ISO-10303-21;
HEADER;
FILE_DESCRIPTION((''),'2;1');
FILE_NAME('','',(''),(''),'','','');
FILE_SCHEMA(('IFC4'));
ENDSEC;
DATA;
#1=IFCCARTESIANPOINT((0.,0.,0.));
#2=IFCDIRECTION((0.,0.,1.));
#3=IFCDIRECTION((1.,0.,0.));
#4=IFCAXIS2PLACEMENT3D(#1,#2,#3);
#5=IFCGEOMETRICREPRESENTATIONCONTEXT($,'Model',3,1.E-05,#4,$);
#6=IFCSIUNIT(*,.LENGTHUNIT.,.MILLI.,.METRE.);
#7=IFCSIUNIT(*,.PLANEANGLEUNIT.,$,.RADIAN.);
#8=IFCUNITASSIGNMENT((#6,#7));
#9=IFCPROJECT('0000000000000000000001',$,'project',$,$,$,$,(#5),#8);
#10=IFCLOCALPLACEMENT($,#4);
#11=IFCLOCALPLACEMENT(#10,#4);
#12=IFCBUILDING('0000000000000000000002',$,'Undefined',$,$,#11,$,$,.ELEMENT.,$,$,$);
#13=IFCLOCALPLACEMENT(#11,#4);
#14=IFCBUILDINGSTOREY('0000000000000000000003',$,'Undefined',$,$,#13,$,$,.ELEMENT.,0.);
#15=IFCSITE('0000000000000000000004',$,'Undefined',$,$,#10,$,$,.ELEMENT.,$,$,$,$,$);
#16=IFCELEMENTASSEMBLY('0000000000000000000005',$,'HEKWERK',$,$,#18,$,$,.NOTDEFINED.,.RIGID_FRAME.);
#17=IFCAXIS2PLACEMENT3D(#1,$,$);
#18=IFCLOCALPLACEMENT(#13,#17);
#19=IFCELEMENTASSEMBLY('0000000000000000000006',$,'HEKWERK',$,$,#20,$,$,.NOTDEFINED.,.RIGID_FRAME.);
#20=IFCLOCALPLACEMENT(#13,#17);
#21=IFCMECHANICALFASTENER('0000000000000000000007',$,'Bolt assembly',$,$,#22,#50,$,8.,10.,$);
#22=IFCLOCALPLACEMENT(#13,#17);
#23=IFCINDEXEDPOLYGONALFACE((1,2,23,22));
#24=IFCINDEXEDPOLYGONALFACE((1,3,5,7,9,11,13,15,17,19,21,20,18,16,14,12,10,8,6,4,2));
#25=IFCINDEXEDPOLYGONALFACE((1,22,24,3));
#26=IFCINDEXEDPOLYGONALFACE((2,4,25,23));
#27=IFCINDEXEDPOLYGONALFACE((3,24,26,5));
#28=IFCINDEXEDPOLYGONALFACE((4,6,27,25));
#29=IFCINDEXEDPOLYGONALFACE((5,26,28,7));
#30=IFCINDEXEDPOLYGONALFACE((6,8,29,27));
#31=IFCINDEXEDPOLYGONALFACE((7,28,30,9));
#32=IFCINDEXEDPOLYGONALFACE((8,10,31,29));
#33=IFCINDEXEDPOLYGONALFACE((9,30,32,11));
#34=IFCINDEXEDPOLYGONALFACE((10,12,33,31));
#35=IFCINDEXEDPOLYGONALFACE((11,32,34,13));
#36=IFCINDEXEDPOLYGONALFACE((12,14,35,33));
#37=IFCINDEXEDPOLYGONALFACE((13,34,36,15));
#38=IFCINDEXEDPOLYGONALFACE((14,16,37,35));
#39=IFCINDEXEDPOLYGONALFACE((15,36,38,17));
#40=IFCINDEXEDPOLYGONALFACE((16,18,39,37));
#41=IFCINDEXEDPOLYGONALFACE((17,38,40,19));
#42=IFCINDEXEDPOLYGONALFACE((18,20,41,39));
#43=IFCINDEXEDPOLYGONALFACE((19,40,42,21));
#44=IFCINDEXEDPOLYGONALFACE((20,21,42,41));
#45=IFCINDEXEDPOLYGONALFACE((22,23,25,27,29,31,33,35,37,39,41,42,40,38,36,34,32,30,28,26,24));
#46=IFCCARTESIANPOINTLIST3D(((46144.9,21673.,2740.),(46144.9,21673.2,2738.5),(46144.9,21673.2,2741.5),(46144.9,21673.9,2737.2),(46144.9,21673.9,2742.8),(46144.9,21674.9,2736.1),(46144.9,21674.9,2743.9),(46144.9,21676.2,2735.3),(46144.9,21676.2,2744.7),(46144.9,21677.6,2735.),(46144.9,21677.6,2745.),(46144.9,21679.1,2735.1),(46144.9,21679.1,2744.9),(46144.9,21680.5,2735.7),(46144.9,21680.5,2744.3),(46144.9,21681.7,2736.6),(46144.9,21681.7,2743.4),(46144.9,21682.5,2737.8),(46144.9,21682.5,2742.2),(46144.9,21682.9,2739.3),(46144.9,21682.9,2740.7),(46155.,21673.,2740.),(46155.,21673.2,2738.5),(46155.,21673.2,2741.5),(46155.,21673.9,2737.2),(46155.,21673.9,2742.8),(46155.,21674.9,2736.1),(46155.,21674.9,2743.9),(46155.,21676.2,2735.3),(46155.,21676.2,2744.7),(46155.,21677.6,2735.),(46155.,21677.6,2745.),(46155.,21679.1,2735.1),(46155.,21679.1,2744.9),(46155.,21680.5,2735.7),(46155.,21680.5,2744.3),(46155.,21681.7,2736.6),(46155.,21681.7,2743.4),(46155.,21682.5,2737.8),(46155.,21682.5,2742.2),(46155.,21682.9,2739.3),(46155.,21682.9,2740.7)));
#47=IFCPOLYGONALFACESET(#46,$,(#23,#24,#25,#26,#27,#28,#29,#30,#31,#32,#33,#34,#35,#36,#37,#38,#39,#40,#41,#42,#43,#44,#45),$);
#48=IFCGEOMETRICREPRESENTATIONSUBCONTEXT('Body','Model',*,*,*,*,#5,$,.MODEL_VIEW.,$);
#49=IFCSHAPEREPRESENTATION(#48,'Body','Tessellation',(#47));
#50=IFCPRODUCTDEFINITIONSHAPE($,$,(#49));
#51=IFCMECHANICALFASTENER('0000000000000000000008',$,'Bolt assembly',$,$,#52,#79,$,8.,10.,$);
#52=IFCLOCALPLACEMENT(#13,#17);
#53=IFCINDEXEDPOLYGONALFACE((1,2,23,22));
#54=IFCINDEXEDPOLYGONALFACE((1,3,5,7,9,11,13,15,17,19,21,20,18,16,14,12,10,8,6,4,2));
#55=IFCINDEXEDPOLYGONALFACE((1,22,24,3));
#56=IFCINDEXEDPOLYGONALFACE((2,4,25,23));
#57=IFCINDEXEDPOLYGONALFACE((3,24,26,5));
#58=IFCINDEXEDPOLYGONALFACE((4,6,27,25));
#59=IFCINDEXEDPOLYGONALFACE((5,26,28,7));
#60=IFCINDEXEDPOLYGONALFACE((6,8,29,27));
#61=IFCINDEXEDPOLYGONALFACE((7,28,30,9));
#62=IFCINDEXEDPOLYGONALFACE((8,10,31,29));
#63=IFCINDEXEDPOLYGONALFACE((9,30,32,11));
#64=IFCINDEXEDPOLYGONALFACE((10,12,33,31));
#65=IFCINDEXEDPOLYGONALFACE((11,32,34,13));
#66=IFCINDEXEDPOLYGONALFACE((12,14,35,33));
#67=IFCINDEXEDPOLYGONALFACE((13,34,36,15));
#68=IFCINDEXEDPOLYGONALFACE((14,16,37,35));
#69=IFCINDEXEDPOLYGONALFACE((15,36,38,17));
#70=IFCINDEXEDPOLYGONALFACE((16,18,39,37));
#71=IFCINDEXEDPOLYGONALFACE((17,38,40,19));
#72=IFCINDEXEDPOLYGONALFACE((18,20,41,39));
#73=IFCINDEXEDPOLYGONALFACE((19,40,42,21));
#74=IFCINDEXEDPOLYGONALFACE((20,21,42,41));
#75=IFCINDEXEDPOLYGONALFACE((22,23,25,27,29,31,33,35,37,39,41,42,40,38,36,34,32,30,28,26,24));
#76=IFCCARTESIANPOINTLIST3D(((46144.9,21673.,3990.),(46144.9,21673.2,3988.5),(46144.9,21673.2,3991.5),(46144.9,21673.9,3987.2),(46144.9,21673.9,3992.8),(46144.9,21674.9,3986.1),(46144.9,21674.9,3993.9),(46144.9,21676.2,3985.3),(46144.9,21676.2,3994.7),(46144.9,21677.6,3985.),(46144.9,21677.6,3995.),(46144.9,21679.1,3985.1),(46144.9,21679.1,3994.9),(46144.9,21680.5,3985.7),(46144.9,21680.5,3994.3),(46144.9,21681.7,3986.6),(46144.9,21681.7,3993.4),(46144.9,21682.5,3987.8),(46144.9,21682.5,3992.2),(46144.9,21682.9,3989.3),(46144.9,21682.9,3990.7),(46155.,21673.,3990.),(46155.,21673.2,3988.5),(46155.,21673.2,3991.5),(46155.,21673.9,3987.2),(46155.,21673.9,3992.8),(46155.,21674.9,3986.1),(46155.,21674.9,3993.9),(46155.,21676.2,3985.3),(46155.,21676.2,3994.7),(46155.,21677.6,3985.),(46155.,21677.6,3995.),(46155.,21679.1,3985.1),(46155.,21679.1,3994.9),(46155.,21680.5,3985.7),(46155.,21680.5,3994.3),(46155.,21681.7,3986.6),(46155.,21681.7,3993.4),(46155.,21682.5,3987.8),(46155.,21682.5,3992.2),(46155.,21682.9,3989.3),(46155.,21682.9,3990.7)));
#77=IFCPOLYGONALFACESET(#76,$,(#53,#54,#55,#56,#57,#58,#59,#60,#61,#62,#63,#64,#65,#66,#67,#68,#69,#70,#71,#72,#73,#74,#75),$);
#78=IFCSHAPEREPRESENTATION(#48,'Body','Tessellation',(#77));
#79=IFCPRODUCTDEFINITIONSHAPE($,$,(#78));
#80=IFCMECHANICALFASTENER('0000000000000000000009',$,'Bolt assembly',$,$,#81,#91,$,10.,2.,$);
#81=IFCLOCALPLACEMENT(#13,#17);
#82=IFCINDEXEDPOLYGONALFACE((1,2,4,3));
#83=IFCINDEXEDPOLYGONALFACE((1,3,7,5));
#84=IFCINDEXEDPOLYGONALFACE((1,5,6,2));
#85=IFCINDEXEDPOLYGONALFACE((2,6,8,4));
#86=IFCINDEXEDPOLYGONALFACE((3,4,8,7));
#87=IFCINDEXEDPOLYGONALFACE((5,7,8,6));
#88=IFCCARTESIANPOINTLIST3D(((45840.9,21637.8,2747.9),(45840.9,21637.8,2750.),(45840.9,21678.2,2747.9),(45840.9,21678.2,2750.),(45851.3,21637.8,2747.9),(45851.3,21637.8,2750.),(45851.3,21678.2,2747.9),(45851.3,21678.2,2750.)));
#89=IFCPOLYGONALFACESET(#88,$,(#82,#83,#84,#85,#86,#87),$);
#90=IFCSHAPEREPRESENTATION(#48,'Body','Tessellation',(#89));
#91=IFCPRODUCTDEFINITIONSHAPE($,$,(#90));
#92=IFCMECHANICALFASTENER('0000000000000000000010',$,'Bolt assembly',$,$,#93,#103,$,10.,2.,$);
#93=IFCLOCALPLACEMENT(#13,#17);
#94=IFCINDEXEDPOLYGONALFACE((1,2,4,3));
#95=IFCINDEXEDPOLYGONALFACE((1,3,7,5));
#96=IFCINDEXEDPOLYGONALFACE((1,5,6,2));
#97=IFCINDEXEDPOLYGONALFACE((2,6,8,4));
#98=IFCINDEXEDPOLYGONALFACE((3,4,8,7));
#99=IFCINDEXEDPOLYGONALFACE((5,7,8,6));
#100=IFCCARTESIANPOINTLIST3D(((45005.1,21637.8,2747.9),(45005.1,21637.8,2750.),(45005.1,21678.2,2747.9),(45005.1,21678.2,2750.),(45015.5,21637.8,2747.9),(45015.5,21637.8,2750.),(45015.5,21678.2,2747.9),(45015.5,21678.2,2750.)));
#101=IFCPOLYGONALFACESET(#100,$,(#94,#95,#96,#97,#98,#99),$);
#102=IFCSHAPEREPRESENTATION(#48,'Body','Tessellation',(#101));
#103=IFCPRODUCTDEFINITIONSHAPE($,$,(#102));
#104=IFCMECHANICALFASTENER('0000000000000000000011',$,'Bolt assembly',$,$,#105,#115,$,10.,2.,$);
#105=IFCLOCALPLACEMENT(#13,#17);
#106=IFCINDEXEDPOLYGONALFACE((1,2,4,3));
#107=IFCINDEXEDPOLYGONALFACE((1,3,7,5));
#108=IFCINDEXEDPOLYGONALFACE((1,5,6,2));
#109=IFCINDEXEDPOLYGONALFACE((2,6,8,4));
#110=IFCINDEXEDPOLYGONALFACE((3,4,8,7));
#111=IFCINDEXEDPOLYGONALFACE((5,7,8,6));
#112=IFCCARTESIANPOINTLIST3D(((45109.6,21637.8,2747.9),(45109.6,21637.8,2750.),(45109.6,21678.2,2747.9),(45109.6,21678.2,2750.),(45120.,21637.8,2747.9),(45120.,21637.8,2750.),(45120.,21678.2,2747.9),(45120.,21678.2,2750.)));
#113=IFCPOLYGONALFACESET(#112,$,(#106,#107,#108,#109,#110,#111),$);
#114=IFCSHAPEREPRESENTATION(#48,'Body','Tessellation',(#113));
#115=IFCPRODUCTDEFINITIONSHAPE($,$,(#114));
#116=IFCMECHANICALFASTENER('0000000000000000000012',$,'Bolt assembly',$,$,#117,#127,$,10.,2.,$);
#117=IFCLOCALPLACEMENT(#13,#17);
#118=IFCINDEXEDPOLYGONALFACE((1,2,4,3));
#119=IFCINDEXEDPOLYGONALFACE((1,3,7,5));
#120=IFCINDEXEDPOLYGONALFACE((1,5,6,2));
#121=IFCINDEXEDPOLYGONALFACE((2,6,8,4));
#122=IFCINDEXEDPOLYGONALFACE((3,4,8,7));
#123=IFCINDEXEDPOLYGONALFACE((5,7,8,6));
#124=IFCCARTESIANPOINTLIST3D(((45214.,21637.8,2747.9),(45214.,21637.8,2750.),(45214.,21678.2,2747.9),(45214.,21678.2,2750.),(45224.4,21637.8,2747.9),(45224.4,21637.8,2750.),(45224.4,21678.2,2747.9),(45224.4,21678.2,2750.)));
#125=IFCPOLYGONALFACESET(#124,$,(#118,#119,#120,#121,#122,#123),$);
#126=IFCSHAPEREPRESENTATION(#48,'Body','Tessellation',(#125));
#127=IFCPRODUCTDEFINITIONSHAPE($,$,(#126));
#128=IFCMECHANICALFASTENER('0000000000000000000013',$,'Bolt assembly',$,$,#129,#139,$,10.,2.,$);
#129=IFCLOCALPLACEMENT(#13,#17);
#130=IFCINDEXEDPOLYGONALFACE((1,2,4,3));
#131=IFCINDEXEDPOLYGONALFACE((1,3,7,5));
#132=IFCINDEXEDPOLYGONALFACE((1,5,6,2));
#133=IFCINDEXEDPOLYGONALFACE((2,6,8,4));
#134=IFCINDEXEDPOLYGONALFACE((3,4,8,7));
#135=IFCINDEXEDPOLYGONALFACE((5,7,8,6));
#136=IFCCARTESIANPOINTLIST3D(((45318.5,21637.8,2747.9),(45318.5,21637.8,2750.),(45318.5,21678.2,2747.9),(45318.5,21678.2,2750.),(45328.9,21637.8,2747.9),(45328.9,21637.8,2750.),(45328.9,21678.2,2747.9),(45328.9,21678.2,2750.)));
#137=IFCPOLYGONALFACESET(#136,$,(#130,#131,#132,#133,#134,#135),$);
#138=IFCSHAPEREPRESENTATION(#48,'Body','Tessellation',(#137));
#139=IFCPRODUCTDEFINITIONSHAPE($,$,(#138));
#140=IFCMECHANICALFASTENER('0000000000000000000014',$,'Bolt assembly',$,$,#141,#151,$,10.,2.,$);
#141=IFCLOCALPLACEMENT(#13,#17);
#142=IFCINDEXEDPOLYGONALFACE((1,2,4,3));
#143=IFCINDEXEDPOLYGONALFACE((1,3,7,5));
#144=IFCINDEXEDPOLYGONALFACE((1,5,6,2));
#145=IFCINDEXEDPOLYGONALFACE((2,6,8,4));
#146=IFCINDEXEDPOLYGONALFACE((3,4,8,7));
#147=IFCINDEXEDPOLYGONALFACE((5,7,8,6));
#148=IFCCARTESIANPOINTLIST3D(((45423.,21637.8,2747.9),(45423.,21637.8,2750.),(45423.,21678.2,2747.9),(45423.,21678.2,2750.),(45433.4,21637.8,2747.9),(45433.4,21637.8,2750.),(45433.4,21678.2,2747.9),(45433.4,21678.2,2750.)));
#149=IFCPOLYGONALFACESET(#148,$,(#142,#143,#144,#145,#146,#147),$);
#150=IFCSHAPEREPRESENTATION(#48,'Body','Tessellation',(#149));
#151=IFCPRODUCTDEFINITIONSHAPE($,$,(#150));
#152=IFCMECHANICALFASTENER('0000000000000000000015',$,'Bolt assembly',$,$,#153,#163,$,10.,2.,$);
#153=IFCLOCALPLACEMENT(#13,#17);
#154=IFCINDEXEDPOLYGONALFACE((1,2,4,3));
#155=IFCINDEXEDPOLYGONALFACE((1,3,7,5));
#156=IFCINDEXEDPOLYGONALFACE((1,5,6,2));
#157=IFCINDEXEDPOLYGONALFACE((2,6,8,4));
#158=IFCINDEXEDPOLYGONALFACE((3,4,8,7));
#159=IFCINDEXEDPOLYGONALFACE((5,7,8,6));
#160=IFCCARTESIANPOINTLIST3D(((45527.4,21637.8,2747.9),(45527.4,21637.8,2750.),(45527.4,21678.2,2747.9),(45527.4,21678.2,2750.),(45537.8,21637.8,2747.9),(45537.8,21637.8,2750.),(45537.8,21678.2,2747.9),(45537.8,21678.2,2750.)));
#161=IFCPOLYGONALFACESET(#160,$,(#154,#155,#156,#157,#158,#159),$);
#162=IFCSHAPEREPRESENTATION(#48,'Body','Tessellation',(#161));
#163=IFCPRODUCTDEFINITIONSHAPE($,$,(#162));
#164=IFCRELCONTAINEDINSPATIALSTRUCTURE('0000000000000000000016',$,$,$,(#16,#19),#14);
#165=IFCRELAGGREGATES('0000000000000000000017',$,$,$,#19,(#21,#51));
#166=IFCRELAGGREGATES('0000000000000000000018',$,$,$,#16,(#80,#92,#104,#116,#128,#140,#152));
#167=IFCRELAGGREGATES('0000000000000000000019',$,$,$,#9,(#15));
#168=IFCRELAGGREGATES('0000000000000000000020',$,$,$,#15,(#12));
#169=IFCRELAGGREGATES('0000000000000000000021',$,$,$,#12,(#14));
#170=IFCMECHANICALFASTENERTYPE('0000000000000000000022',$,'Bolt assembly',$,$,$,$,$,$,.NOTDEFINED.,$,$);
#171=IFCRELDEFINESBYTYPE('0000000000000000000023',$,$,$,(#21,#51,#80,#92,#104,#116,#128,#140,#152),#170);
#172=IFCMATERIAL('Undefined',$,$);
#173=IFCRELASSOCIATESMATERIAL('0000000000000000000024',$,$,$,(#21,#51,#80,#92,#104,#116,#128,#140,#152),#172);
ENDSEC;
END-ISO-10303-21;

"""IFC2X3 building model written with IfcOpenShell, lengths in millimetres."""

from ifc_helpers import new_model, si_unit, frame, origin_with_axes, origin_2d_with_axis, place, context, subcontext, project, spatial, polyline, segment, composite_curve, circle, outline, extrude, source, transform, mapped, material, type_object, element, aggregate, save


model = new_model("IFC2X3")

# Units and contexts
model_context = context("Model", 3, precision=1e-05, world=origin_with_axes())
body_context = subcontext(model_context, "Body", "Model", "MODEL_VIEW")
ifc_project = project(units=[si_unit("LENGTHUNIT", "METRE", prefix="MILLI"), si_unit("PLANEANGLEUNIT", "RADIAN")], contexts=[model_context])

# Site, building, storey
site_placement = place(None, origin_with_axes())
site = spatial("IfcSite", under=ifc_project, at=site_placement, Name="Undefined", CompositionType="ELEMENT")
building_placement = place(site_placement, origin_with_axes())
building = spatial("IfcBuilding", under=site, at=building_placement, Name="Undefined", CompositionType="ELEMENT")
storey_placement = place(building_placement, origin_with_axes())
storey = spatial("IfcBuildingStorey", under=building, at=storey_placement, Name="Undefined", CompositionType="ELEMENT", Elevation=0.0)

# Element assembly
assembly_1_placement = place(storey_placement, origin_with_axes())
assembly_1 = element("IfcElementAssembly", 1, at=assembly_1_placement, inside=storey, Name="HEKWERK", AssemblyPlace="NOTDEFINED", PredefinedType="RIGID_FRAME")

# Element assembly
assembly_2_placement = place(storey_placement, origin_with_axes())
assembly_2 = element("IfcElementAssembly", 2, at=assembly_2_placement, inside=storey, Name="HEKWERK", AssemblyPlace="NOTDEFINED", PredefinedType="RIGID_FRAME")

# Mechanical fasteners
ifc_material_1 = material(Name="Undefined")
mechanical_fastener_type = type_object("IfcMechanicalFastenerType", Name="Bolt assembly")
shared_shape_1 = source(origin_with_axes(), body_context, "Body", "SweptSolid", [
    extrude(circle(Radius=5.0, at=origin_2d_with_axis()), frame((0.0, 0.0, 0.0), z_axis=(0.0, 1.0, 0.0), x_axis=(1.0, 0.0, 0.0)), (0.0, 0.0, 1.0), 10.1),
])
mechanical_fastener_1_placement = place(assembly_2_placement, frame((46155.0, 21678.0, 2740.0), z_axis=(0.0, 0.0, -1.0), x_axis=(0.0, -1.0, 0.0)))
mechanical_fastener_1 = element("IfcMechanicalFastener", 3, at=mechanical_fastener_1_placement, type_object=mechanical_fastener_type, material=ifc_material_1, Name="Bolt assembly", NominalDiameter=8.0, NominalLength=10.0, context=body_context, shape_type="MappedRepresentation", body=[
    mapped(shared_shape_1, transform((0.0, 0.0, 0.0))),
])
mechanical_fastener_2_placement = place(assembly_2_placement, frame((46155.0, 21678.0, 3990.0), z_axis=(0.0, 0.0, -1.0), x_axis=(0.0, -1.0, 0.0)))
mechanical_fastener_2 = element("IfcMechanicalFastener", 4, at=mechanical_fastener_2_placement, type_object=mechanical_fastener_type, material=ifc_material_1, Name="Bolt assembly", NominalDiameter=8.0, NominalLength=10.0, context=body_context, shape_type="MappedRepresentation", body=[
    mapped(shared_shape_1, transform((0.0, 0.0, 0.0))),
])
shared_shape_2 = source(origin_with_axes(), body_context, "Body", "SweptSolid", [
    extrude(outline(composite_curve([segment(polyline([(-20.2, 5.2), (20.2, 5.2)]), True, "CONTINUOUS"), segment(polyline([(20.2, 5.2), (20.2, -5.2)]), True, "CONTINUOUS"), segment(polyline([(20.2, -5.2), (-20.2, -5.2)]), True, "CONTINUOUS"), segment(polyline([(-20.2, -5.2), (-20.2, 5.2)]), True, "CONTINUOUS")], self_intersect=False)), frame((0.0, -1.0, 0.0), z_axis=(0.0, 1.0, 0.0), x_axis=(1.0, 0.0, 0.0)), (0.0, 0.0, 1.0), 2.1),
])
mechanical_fastener_3_placement = place(assembly_1_placement, frame((45846.1, 21658.0, 2749.0), z_axis=(-1.0, 0.0, 0.0), x_axis=(0.0, 1.0, 0.0)))
mechanical_fastener_3 = element("IfcMechanicalFastener", 5, at=mechanical_fastener_3_placement, type_object=mechanical_fastener_type, material=ifc_material_1, Name="Bolt assembly", NominalDiameter=10.0, NominalLength=2.0, context=body_context, shape_type="MappedRepresentation", body=[
    mapped(shared_shape_2, transform((0.0, 0.0, 0.0))),
])
shared_shape_3 = source(origin_with_axes(), body_context, "Body", "SweptSolid", [
    extrude(outline(composite_curve([segment(polyline([(-20.2, 5.2), (20.2, 5.2)]), True, "CONTINUOUS"), segment(polyline([(20.2, 5.2), (20.2, -5.2)]), True, "CONTINUOUS"), segment(polyline([(20.2, -5.2), (-20.2, -5.2)]), True, "CONTINUOUS"), segment(polyline([(-20.2, -5.2), (-20.2, 5.2)]), True, "CONTINUOUS")], self_intersect=False)), frame((0.0, -1.0, 0.0), z_axis=(0.0, 1.0, 0.0), x_axis=(1.0, 0.0, 0.0)), (0.0, 0.0, 1.0), 2.1),
])
mechanical_fastener_4_placement = place(assembly_1_placement, frame((45010.3, 21658.0, 2749.0), z_axis=(-1.0, 0.0, 0.0), x_axis=(0.0, 1.0, 0.0)))
mechanical_fastener_4 = element("IfcMechanicalFastener", 6, at=mechanical_fastener_4_placement, type_object=mechanical_fastener_type, material=ifc_material_1, Name="Bolt assembly", NominalDiameter=10.0, NominalLength=2.0, context=body_context, shape_type="MappedRepresentation", body=[
    mapped(shared_shape_3, transform((0.0, 0.0, 0.0))),
])
shared_shape_4 = source(origin_with_axes(), body_context, "Body", "SweptSolid", [
    extrude(outline(composite_curve([segment(polyline([(-20.2, 5.2), (20.2, 5.2)]), True, "CONTINUOUS"), segment(polyline([(20.2, 5.2), (20.2, -5.2)]), True, "CONTINUOUS"), segment(polyline([(20.2, -5.2), (-20.2, -5.2)]), True, "CONTINUOUS"), segment(polyline([(-20.2, -5.2), (-20.2, 5.2)]), True, "CONTINUOUS")], self_intersect=False)), frame((0.0, -1.0, 0.0), z_axis=(0.0, 1.0, 0.0), x_axis=(1.0, 0.0, 0.0)), (0.0, 0.0, 1.0), 2.1),
])
mechanical_fastener_5_placement = place(assembly_1_placement, frame((45114.8, 21658.0, 2749.0), z_axis=(-1.0, 0.0, 0.0), x_axis=(0.0, 1.0, 0.0)))
mechanical_fastener_5 = element("IfcMechanicalFastener", 7, at=mechanical_fastener_5_placement, type_object=mechanical_fastener_type, material=ifc_material_1, Name="Bolt assembly", NominalDiameter=10.0, NominalLength=2.0, context=body_context, shape_type="MappedRepresentation", body=[
    mapped(shared_shape_4, transform((0.0, 0.0, 0.0))),
])
shared_shape_5 = source(origin_with_axes(), body_context, "Body", "SweptSolid", [
    extrude(outline(composite_curve([segment(polyline([(-20.2, 5.2), (20.2, 5.2)]), True, "CONTINUOUS"), segment(polyline([(20.2, 5.2), (20.2, -5.2)]), True, "CONTINUOUS"), segment(polyline([(20.2, -5.2), (-20.2, -5.2)]), True, "CONTINUOUS"), segment(polyline([(-20.2, -5.2), (-20.2, 5.2)]), True, "CONTINUOUS")], self_intersect=False)), frame((0.0, -1.0, 0.0), z_axis=(0.0, 1.0, 0.0), x_axis=(1.0, 0.0, 0.0)), (0.0, 0.0, 1.0), 2.1),
])
mechanical_fastener_6_placement = place(assembly_1_placement, frame((45219.2, 21658.0, 2749.0), z_axis=(-1.0, 0.0, 0.0), x_axis=(0.0, 1.0, 0.0)))
mechanical_fastener_6 = element("IfcMechanicalFastener", 8, at=mechanical_fastener_6_placement, type_object=mechanical_fastener_type, material=ifc_material_1, Name="Bolt assembly", NominalDiameter=10.0, NominalLength=2.0, context=body_context, shape_type="MappedRepresentation", body=[
    mapped(shared_shape_5, transform((0.0, 0.0, 0.0))),
])
shared_shape_6 = source(origin_with_axes(), body_context, "Body", "SweptSolid", [
    extrude(outline(composite_curve([segment(polyline([(-20.2, 5.2), (20.2, 5.2)]), True, "CONTINUOUS"), segment(polyline([(20.2, 5.2), (20.2, -5.2)]), True, "CONTINUOUS"), segment(polyline([(20.2, -5.2), (-20.2, -5.2)]), True, "CONTINUOUS"), segment(polyline([(-20.2, -5.2), (-20.2, 5.2)]), True, "CONTINUOUS")], self_intersect=False)), frame((0.0, -1.0, 0.0), z_axis=(0.0, 1.0, 0.0), x_axis=(1.0, 0.0, 0.0)), (0.0, 0.0, 1.0), 2.1),
])
mechanical_fastener_7_placement = place(assembly_1_placement, frame((45323.7, 21658.0, 2749.0), z_axis=(-1.0, 0.0, 0.0), x_axis=(0.0, 1.0, 0.0)))
mechanical_fastener_7 = element("IfcMechanicalFastener", 9, at=mechanical_fastener_7_placement, type_object=mechanical_fastener_type, material=ifc_material_1, Name="Bolt assembly", NominalDiameter=10.0, NominalLength=2.0, context=body_context, shape_type="MappedRepresentation", body=[
    mapped(shared_shape_6, transform((0.0, 0.0, 0.0))),
])
shared_shape_7 = source(origin_with_axes(), body_context, "Body", "SweptSolid", [
    extrude(outline(composite_curve([segment(polyline([(-20.2, 5.2), (20.2, 5.2)]), True, "CONTINUOUS"), segment(polyline([(20.2, 5.2), (20.2, -5.2)]), True, "CONTINUOUS"), segment(polyline([(20.2, -5.2), (-20.2, -5.2)]), True, "CONTINUOUS"), segment(polyline([(-20.2, -5.2), (-20.2, 5.2)]), True, "CONTINUOUS")], self_intersect=False)), frame((0.0, -1.0, 0.0), z_axis=(0.0, 1.0, 0.0), x_axis=(1.0, 0.0, 0.0)), (0.0, 0.0, 1.0), 2.1),
])
mechanical_fastener_8_placement = place(assembly_1_placement, frame((45428.2, 21658.0, 2749.0), z_axis=(-1.0, 0.0, 0.0), x_axis=(0.0, 1.0, 0.0)))
mechanical_fastener_8 = element("IfcMechanicalFastener", 10, at=mechanical_fastener_8_placement, type_object=mechanical_fastener_type, material=ifc_material_1, Name="Bolt assembly", NominalDiameter=10.0, NominalLength=2.0, context=body_context, shape_type="MappedRepresentation", body=[
    mapped(shared_shape_7, transform((0.0, 0.0, 0.0))),
])
shared_shape_8 = source(origin_with_axes(), body_context, "Body", "SweptSolid", [
    extrude(outline(composite_curve([segment(polyline([(-20.2, 5.2), (20.2, 5.2)]), True, "CONTINUOUS"), segment(polyline([(20.2, 5.2), (20.2, -5.2)]), True, "CONTINUOUS"), segment(polyline([(20.2, -5.2), (-20.2, -5.2)]), True, "CONTINUOUS"), segment(polyline([(-20.2, -5.2), (-20.2, 5.2)]), True, "CONTINUOUS")], self_intersect=False)), frame((0.0, -1.0, 0.0), z_axis=(0.0, 1.0, 0.0), x_axis=(1.0, 0.0, 0.0)), (0.0, 0.0, 1.0), 2.1),
])
mechanical_fastener_9_placement = place(assembly_1_placement, frame((45532.6, 21658.0, 2749.0), z_axis=(-1.0, 0.0, 0.0), x_axis=(0.0, 1.0, 0.0)))
mechanical_fastener_9 = element("IfcMechanicalFastener", 11, at=mechanical_fastener_9_placement, type_object=mechanical_fastener_type, material=ifc_material_1, Name="Bolt assembly", NominalDiameter=10.0, NominalLength=2.0, context=body_context, shape_type="MappedRepresentation", body=[
    mapped(shared_shape_8, transform((0.0, 0.0, 0.0))),
])
aggregate(assembly_2, [mechanical_fastener_1, mechanical_fastener_2])
aggregate(assembly_1, [mechanical_fastener_3, mechanical_fastener_4, mechanical_fastener_5, mechanical_fastener_6, mechanical_fastener_7, mechanical_fastener_8, mechanical_fastener_9])

save(model, "model.ifc")
